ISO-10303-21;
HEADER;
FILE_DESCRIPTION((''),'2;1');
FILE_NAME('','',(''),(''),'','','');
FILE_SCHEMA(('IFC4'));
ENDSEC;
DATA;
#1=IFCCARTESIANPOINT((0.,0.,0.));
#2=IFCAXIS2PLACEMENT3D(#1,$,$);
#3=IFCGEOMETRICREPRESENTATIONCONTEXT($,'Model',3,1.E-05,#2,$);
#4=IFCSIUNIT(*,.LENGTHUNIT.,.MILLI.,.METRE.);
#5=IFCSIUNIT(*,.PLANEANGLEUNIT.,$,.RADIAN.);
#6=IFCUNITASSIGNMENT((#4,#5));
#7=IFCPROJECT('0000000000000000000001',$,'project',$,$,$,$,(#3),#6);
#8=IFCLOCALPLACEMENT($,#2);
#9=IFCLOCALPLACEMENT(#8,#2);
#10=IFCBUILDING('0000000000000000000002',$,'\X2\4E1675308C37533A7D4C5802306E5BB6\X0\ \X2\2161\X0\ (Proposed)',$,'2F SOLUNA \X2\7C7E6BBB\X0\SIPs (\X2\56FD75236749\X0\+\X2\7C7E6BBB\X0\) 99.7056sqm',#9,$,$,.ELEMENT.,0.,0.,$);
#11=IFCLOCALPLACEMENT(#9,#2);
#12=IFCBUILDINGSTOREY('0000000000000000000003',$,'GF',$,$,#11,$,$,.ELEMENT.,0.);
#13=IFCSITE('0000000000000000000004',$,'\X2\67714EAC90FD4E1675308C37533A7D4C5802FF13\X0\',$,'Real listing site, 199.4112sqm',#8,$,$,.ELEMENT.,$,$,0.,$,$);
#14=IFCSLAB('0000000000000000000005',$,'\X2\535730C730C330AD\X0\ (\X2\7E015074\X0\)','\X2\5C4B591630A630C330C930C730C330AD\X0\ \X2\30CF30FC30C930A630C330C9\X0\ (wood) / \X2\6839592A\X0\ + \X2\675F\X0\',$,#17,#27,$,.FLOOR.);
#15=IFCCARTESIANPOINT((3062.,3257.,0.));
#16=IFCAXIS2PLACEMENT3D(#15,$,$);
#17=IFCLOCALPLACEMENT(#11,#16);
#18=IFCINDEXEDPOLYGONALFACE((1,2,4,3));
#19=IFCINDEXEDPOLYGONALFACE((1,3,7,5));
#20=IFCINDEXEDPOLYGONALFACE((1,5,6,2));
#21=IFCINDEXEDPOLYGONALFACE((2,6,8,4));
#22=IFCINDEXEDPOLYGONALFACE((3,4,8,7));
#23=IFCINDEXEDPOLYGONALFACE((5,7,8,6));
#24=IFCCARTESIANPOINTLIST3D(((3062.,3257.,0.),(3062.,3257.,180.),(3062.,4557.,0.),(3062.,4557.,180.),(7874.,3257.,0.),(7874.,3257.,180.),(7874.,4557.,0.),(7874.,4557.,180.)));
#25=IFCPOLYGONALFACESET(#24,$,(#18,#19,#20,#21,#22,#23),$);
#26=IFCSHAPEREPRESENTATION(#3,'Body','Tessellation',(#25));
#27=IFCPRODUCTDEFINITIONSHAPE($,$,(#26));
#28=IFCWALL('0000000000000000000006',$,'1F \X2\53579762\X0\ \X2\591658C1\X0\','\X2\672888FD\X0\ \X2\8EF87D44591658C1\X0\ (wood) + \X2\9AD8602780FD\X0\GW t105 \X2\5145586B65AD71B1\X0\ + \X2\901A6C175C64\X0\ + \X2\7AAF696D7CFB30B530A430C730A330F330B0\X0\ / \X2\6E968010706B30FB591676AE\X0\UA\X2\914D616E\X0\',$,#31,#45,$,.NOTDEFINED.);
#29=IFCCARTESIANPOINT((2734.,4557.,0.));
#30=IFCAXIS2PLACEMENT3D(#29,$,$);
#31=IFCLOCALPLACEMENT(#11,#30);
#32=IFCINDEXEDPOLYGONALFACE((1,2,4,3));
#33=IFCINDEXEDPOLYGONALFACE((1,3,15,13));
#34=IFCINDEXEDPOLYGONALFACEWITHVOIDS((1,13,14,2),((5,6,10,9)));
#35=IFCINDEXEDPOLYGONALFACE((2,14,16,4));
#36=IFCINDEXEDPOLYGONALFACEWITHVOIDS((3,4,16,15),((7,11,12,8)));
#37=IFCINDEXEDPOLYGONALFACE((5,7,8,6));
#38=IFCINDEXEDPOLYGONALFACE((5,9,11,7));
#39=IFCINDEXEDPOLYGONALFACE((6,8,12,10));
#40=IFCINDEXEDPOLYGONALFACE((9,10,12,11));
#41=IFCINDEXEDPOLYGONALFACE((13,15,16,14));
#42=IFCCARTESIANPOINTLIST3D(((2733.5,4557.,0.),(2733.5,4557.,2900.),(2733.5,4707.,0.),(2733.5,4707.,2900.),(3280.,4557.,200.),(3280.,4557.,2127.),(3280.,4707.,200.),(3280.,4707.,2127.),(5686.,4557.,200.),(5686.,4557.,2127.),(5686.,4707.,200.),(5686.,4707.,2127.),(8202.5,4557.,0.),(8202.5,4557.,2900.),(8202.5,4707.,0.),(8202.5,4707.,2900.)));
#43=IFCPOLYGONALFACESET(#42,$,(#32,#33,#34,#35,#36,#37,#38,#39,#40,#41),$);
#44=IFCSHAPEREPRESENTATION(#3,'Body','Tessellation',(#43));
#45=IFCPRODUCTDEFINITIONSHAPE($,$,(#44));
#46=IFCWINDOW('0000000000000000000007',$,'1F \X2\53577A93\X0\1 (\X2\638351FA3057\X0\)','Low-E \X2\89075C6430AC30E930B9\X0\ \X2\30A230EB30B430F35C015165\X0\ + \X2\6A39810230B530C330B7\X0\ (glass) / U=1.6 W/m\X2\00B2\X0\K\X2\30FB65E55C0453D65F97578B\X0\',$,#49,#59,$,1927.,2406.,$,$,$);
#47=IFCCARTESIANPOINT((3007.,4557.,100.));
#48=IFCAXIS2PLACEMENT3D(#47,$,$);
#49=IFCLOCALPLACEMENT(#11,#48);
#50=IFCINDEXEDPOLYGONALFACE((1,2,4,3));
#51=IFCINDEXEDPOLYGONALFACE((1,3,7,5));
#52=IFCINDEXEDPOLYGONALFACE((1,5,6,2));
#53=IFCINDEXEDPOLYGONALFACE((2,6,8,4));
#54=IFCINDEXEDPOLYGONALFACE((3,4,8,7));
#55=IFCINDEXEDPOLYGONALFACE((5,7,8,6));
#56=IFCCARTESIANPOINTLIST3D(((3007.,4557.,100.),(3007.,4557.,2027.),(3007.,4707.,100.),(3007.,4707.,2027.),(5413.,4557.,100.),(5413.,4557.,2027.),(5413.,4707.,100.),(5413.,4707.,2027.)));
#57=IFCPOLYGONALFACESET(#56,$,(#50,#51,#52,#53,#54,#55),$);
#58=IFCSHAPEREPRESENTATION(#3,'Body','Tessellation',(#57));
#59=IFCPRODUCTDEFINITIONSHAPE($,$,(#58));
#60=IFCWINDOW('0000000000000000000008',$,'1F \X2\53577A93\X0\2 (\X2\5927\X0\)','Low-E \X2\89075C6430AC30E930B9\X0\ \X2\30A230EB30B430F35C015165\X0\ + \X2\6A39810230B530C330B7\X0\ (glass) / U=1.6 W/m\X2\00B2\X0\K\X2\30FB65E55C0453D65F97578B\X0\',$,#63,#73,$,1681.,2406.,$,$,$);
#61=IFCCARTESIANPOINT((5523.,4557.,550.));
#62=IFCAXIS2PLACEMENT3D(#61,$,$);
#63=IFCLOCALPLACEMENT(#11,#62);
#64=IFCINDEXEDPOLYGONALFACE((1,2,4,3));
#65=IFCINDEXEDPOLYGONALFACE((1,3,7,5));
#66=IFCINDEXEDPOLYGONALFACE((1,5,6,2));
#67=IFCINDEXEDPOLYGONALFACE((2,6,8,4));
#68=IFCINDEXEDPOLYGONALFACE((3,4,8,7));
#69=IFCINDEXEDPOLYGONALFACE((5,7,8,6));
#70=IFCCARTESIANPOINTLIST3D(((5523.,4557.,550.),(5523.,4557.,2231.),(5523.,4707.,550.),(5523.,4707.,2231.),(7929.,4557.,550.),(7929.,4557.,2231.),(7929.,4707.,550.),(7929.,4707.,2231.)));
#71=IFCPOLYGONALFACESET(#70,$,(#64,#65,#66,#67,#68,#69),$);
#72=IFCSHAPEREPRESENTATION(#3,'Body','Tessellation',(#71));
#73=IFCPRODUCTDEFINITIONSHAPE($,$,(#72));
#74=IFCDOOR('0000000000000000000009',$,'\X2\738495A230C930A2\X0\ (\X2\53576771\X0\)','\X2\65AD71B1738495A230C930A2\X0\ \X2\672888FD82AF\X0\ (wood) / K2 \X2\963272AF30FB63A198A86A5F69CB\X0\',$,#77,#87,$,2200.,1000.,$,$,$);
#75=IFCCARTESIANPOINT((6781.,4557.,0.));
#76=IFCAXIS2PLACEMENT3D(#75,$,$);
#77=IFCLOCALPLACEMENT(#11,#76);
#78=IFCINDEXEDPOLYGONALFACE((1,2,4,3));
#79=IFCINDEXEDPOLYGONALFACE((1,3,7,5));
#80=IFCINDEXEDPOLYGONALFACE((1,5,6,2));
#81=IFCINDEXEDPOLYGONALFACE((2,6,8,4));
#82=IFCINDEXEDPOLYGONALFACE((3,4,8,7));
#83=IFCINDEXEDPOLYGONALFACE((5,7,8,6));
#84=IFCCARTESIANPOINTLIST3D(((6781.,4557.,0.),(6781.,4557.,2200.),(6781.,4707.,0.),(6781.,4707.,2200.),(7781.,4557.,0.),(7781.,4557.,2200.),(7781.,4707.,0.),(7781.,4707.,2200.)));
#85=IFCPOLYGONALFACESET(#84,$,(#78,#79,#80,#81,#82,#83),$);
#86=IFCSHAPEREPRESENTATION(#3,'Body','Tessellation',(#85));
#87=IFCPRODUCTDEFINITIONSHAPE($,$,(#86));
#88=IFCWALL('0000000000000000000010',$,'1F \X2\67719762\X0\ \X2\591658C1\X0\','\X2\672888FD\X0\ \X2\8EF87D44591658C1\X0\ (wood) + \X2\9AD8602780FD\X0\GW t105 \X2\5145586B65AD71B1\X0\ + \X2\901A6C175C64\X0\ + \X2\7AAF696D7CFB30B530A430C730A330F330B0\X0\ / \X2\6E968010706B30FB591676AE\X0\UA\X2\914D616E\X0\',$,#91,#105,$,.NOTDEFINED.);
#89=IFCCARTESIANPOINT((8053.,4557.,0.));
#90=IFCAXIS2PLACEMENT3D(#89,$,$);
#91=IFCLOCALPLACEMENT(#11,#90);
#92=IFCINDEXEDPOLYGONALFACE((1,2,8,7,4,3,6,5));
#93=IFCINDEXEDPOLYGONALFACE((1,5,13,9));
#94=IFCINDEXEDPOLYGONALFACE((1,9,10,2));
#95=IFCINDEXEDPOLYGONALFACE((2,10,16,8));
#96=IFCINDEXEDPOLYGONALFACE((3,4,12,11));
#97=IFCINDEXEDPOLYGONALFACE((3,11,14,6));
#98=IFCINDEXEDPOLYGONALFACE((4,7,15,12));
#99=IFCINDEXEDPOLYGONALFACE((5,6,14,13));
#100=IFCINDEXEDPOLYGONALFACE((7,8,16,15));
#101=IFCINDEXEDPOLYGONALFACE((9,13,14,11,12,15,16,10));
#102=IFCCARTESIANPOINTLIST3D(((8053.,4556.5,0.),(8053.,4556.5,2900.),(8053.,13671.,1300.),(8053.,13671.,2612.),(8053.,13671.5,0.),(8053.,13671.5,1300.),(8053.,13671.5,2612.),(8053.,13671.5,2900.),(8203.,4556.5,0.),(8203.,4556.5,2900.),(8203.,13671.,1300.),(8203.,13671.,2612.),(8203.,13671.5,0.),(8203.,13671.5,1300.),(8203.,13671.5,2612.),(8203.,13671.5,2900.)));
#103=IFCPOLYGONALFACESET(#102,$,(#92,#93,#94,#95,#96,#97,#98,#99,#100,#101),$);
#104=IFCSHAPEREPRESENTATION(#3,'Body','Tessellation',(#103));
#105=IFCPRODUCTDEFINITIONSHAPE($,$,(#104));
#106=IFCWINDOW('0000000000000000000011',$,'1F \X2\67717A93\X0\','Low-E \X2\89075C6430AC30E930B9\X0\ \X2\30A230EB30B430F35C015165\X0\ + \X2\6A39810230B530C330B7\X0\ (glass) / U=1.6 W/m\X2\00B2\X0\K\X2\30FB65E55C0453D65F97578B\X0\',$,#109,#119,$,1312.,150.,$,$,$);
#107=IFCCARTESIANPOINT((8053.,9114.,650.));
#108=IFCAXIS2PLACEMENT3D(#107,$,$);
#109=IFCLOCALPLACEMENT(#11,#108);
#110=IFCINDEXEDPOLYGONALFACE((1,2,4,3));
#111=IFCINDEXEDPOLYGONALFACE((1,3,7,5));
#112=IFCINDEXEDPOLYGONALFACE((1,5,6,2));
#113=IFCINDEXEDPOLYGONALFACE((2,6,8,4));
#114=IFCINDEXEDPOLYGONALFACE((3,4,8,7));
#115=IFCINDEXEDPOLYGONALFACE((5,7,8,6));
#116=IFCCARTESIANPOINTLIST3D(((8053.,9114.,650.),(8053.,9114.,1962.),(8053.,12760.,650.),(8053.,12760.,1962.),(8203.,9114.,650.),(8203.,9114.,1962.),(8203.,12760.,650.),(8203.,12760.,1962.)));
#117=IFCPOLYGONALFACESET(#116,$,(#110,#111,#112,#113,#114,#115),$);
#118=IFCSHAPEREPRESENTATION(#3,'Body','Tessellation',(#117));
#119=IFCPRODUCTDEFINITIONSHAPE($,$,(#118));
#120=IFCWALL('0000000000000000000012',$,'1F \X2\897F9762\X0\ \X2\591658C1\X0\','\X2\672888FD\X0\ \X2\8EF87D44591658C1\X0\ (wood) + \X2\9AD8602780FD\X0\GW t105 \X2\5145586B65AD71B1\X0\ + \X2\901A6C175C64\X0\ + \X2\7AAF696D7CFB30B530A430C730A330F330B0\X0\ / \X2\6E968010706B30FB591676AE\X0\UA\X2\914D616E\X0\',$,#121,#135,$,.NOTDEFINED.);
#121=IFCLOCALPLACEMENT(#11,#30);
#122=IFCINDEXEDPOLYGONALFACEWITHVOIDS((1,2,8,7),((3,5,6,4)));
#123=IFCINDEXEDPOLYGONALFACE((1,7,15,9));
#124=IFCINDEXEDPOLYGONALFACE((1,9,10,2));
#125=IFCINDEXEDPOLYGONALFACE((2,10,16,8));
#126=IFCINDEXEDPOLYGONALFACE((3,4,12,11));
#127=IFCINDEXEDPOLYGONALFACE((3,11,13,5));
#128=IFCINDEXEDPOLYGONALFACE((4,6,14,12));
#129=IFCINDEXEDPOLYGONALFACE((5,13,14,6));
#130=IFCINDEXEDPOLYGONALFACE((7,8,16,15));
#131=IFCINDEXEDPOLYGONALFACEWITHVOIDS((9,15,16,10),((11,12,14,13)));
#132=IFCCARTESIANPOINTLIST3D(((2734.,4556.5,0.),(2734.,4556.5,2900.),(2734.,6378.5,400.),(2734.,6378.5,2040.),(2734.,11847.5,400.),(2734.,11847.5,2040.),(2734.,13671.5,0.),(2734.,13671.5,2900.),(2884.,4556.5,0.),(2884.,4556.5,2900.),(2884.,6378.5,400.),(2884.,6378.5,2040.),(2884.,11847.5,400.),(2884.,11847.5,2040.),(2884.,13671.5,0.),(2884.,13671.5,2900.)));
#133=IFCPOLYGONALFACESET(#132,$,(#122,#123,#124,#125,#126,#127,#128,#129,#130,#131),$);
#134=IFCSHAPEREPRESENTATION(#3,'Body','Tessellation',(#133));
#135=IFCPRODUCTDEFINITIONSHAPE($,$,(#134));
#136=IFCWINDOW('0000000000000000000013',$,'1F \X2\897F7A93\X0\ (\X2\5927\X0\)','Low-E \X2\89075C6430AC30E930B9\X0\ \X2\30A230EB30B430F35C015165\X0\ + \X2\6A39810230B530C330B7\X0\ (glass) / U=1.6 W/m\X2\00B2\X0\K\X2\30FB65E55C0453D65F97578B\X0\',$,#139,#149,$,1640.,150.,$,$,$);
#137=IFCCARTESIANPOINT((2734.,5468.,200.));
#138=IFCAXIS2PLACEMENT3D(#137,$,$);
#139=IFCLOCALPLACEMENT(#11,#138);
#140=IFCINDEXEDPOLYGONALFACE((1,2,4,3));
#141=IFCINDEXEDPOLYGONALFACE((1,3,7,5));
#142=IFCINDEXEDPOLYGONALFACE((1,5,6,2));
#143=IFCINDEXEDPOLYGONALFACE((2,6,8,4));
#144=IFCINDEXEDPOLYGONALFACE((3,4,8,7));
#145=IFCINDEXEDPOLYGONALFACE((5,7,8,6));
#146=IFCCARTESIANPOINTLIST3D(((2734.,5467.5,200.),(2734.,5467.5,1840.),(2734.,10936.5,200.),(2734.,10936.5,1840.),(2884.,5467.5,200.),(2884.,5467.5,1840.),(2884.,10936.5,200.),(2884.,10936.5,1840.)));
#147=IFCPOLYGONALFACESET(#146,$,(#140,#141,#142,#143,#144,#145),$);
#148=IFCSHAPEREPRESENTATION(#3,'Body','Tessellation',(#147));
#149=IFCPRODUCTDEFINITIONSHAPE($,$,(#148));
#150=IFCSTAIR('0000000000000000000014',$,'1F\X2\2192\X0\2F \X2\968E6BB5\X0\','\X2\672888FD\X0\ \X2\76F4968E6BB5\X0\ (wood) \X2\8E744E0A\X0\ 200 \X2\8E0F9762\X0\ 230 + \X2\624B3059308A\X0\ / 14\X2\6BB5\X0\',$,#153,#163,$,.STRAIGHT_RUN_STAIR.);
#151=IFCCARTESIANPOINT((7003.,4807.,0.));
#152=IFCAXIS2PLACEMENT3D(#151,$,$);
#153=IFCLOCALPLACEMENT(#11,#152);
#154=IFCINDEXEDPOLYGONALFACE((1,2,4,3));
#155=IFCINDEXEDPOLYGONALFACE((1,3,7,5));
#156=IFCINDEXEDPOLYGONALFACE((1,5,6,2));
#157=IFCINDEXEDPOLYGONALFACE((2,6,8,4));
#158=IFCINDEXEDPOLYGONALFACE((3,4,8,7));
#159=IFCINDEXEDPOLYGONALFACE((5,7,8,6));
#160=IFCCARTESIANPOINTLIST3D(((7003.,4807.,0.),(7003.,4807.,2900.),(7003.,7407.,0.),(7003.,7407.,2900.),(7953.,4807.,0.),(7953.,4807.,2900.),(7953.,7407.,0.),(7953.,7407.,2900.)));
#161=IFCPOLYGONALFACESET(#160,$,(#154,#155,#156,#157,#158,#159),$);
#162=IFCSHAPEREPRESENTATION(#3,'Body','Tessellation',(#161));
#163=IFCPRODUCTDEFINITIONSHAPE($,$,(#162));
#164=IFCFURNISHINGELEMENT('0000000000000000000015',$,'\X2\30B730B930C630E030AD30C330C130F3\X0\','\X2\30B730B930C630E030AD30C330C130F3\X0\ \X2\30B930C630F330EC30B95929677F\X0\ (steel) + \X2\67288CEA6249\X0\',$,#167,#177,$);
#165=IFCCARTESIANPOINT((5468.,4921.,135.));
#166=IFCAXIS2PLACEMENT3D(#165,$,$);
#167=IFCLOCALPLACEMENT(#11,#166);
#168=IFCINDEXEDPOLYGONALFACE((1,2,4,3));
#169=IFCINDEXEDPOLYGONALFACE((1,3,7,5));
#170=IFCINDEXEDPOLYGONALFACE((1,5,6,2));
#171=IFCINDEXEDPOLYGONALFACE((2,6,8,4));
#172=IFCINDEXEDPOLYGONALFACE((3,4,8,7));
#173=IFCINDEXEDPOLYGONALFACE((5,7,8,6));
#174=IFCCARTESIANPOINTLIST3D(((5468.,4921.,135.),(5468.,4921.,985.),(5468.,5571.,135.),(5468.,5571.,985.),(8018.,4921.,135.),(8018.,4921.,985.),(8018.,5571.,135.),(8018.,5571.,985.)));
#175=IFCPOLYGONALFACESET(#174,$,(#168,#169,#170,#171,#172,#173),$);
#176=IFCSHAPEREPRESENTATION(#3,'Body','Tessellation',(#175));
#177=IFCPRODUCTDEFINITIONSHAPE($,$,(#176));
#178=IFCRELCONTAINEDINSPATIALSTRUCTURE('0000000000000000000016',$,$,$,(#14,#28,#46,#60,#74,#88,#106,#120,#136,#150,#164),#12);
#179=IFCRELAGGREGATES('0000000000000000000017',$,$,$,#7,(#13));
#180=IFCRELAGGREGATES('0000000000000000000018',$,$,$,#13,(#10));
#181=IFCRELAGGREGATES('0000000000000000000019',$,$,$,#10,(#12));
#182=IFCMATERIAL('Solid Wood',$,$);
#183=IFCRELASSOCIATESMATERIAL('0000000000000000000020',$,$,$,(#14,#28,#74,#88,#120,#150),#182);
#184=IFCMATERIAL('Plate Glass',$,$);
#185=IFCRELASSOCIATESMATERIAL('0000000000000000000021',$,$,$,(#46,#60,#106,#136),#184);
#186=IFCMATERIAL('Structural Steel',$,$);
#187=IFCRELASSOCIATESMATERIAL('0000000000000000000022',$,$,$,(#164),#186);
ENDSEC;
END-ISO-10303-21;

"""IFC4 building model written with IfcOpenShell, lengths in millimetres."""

from ifc_helpers import new_model, si_unit, frame, frame_2d, origin, place, context, project, spatial, rectangle, extrude, material, element, fill, save


model = new_model("IFC4")

# Units and contexts
model_context = context("Model", 3, precision=1e-05, world=origin())
ifc_project = project(units=[si_unit("LENGTHUNIT", "METRE", prefix="MILLI"), si_unit("PLANEANGLEUNIT", "RADIAN")], contexts=[model_context])

# Site, building, storey
site_placement = place(None, origin())
site = spatial("IfcSite", under=ifc_project, at=site_placement, Name="東京都世田谷区経堂３", ObjectType="Real listing site, 199.4112sqm", CompositionType="ELEMENT", RefElevation=0.0)
building_placement = place(site_placement, origin())
building = spatial("IfcBuilding", under=site, at=building_placement, Name="世田谷区経堂の家 Ⅱ (Proposed)", ObjectType="2F SOLUNA 籾殻SIPs (国産杉+籾殻) 99.7056sqm", CompositionType="ELEMENT", ElevationOfRefHeight=0.0, ElevationOfTerrain=0.0)
storey_placement = place(building_placement, origin())
storey = spatial("IfcBuildingStorey", under=building, at=storey_placement, Name="GF", CompositionType="ELEMENT", Elevation=0.0)

# Slab
ifc_material_1 = material(Name="Solid Wood")
slab_1_placement = place(storey_placement, frame((3062.0, 3257.0, 0.0)))
element("IfcSlab", 1, at=slab_1_placement, inside=storey, material=ifc_material_1, Name="南デッキ (縁側)", Description="屋外ウッドデッキ ハードウッド (wood) / 根太 + 束", PredefinedType="FLOOR", context=model_context, shape_type="SweptSolid", body=[
    extrude(rectangle(XDim=4812.0, YDim=1300.0, at=frame_2d((2406.0, 650.0))), frame((3062.0, 3257.0, 0.0)), (0.0, 0.0, 1.0), 180.0),
])

# Wall, openings, windows, door
wall_1_placement = place(storey_placement, frame((2734.0, 4557.0, 0.0)))
wall_1 = element("IfcWall", 2, at=wall_1_placement, inside=storey, material=ifc_material_1, Name="1F 南面 外壁", Description="木製 軸組外壁 (wood) + 高性能GW t105 充填断熱 + 通気層 + 窯業系サイディング / 準耐火・外皮UA配慮", PredefinedType="NOTDEFINED", context=model_context, shape_type="SweptSolid", body=[
    extrude(rectangle(XDim=5469.0, YDim=150.0, at=frame_2d((2734.0, 75.0))), frame((2734.0, 4557.0, 0.0)), (0.0, 0.0, 1.0), 2900.0),
])
opening_1_placement = place(storey_placement, frame((3007.0, 4557.0, 100.0)))
opening_1 = element("IfcOpeningElement", 3, at=opening_1_placement, cuts=wall_1, PredefinedType="NOTDEFINED", context=model_context, shape_type="SweptSolid", body=[
    extrude(rectangle(XDim=2406.0, YDim=150.0, at=frame_2d((1203.0, 75.0))), frame((3007.0, 4557.0, 100.0)), (0.0, 0.0, 1.0), 1927.0),
])
opening_2_placement = place(storey_placement, frame((5523.0, 4557.0, 550.0)))
opening_2 = element("IfcOpeningElement", 4, at=opening_2_placement, cuts=wall_1, PredefinedType="NOTDEFINED", context=model_context, shape_type="SweptSolid", body=[
    extrude(rectangle(XDim=2406.0, YDim=150.0, at=frame_2d((1203.0, 75.0))), frame((5523.0, 4557.0, 550.0)), (0.0, 0.0, 1.0), 1681.0),
])
opening_3_placement = place(storey_placement, frame((6781.0, 4557.0, 0.0)))
opening_3 = element("IfcOpeningElement", 5, at=opening_3_placement, cuts=wall_1, PredefinedType="NOTDEFINED", context=model_context, shape_type="SweptSolid", body=[
    extrude(rectangle(XDim=1000.0, YDim=150.0, at=frame_2d((500.0, 75.0))), frame((6781.0, 4557.0, 0.0)), (0.0, 0.0, 1.0), 2200.0),
])
ifc_material_2 = material(Name="Plate Glass")
window_1_placement = place(storey_placement, frame((3007.0, 4557.0, 100.0)))
window_1 = element("IfcWindow", 6, at=window_1_placement, inside=storey, material=ifc_material_2, Name="1F 南窓1 (掃出し)", Description="Low-E 複層ガラス アルゴン封入 + 樹脂サッシ (glass) / U=1.6 W/m²K・日射取得型", OverallHeight=1927.0, OverallWidth=2406.0, context=model_context, shape_type="SweptSolid", body=[
    extrude(rectangle(XDim=2406.0, YDim=150.0, at=frame_2d((1203.0, 75.0))), frame((3007.0, 4557.0, 100.0)), (0.0, 0.0, 1.0), 1927.0),
])
fill(opening_1, window_1)
window_2_placement = place(storey_placement, frame((5523.0, 4557.0, 550.0)))
window_2 = element("IfcWindow", 7, at=window_2_placement, inside=storey, material=ifc_material_2, Name="1F 南窓2 (大)", Description="Low-E 複層ガラス アルゴン封入 + 樹脂サッシ (glass) / U=1.6 W/m²K・日射取得型", OverallHeight=1681.0, OverallWidth=2406.0, context=model_context, shape_type="SweptSolid", body=[
    extrude(rectangle(XDim=2406.0, YDim=150.0, at=frame_2d((1203.0, 75.0))), frame((5523.0, 4557.0, 550.0)), (0.0, 0.0, 1.0), 1681.0),
])
fill(opening_2, window_2)
door_placement = place(storey_placement, frame((6781.0, 4557.0, 0.0)))
door = element("IfcDoor", 8, at=door_placement, inside=storey, material=ifc_material_1, Name="玄関ドア (南東)", Description="断熱玄関ドア 木製芯 (wood) / K2 防犯・採風機構", OverallHeight=2200.0, OverallWidth=1000.0, context=model_context, shape_type="SweptSolid", body=[
    extrude(rectangle(XDim=1000.0, YDim=150.0, at=frame_2d((500.0, 75.0))), frame((6781.0, 4557.0, 0.0)), (0.0, 0.0, 1.0), 2200.0),
])
fill(opening_3, door)

# Walls, openings, windows
wall_2_placement = place(storey_placement, frame((8053.0, 4557.0, 0.0)))
wall_2 = element("IfcWall", 9, at=wall_2_placement, inside=storey, material=ifc_material_1, Name="1F 東面 外壁", Description="木製 軸組外壁 (wood) + 高性能GW t105 充填断熱 + 通気層 + 窯業系サイディング / 準耐火・外皮UA配慮", PredefinedType="NOTDEFINED", context=model_context, shape_type="SweptSolid", body=[
    extrude(rectangle(XDim=150.0, YDim=9115.0, at=frame_2d((75.0, 4557.0))), frame((8053.0, 4557.0, 0.0)), (0.0, 0.0, 1.0), 2900.0),
])
opening_4_placement = place(storey_placement, frame((8053.0, 9114.0, 650.0)))
opening_4 = element("IfcOpeningElement", 10, at=opening_4_placement, cuts=wall_2, PredefinedType="NOTDEFINED", context=model_context, shape_type="SweptSolid", body=[
    extrude(rectangle(XDim=150.0, YDim=3646.0, at=frame_2d((75.0, 1823.0))), frame((8053.0, 9114.0, 650.0)), (0.0, 0.0, 1.0), 1312.0),
])
window_3_placement = place(storey_placement, frame((8053.0, 9114.0, 650.0)))
window_3 = element("IfcWindow", 11, at=window_3_placement, inside=storey, material=ifc_material_2, Name="1F 東窓", Description="Low-E 複層ガラス アルゴン封入 + 樹脂サッシ (glass) / U=1.6 W/m²K・日射取得型", OverallHeight=1312.0, OverallWidth=150.0, context=model_context, shape_type="SweptSolid", body=[
    extrude(rectangle(XDim=150.0, YDim=3646.0, at=frame_2d((75.0, 1823.0))), frame((8053.0, 9114.0, 650.0)), (0.0, 0.0, 1.0), 1312.0),
])
fill(opening_4, window_3)
wall_3_placement = place(storey_placement, frame((2734.0, 4557.0, 0.0)))
wall_3 = element("IfcWall", 12, at=wall_3_placement, inside=storey, material=ifc_material_1, Name="1F 西面 外壁", Description="木製 軸組外壁 (wood) + 高性能GW t105 充填断熱 + 通気層 + 窯業系サイディング / 準耐火・外皮UA配慮", PredefinedType="NOTDEFINED", context=model_context, shape_type="SweptSolid", body=[
    extrude(rectangle(XDim=150.0, YDim=9115.0, at=frame_2d((75.0, 4557.0))), frame((2734.0, 4557.0, 0.0)), (0.0, 0.0, 1.0), 2900.0),
])
opening_5_placement = place(storey_placement, frame((2734.0, 5468.0, 200.0)))
opening_5 = element("IfcOpeningElement", 13, at=opening_5_placement, cuts=wall_3, PredefinedType="NOTDEFINED", context=model_context, shape_type="SweptSolid", body=[
    extrude(rectangle(XDim=150.0, YDim=5469.0, at=frame_2d((75.0, 2734.0))), frame((2734.0, 5468.0, 200.0)), (0.0, 0.0, 1.0), 1640.0),
])
window_4_placement = place(storey_placement, frame((2734.0, 5468.0, 200.0)))
window_4 = element("IfcWindow", 14, at=window_4_placement, inside=storey, material=ifc_material_2, Name="1F 西窓 (大)", Description="Low-E 複層ガラス アルゴン封入 + 樹脂サッシ (glass) / U=1.6 W/m²K・日射取得型", OverallHeight=1640.0, OverallWidth=150.0, context=model_context, shape_type="SweptSolid", body=[
    extrude(rectangle(XDim=150.0, YDim=5469.0, at=frame_2d((75.0, 2734.0))), frame((2734.0, 5468.0, 200.0)), (0.0, 0.0, 1.0), 1640.0),
])
fill(opening_5, window_4)

# Stair
stair_placement = place(storey_placement, frame((7003.0, 4807.0, 0.0)))
element("IfcStair", 15, at=stair_placement, inside=storey, material=ifc_material_1, Name="1F→2F 階段", Description="木製 直階段 (wood) 蹴上 200 踏面 230 + 手すり / 14段", PredefinedType="STRAIGHT_RUN_STAIR", context=model_context, shape_type="SweptSolid", body=[
    extrude(rectangle(XDim=950.0, YDim=2600.0, at=frame_2d((475.0, 1300.0))), frame((7003.0, 4807.0, 0.0)), (0.0, 0.0, 1.0), 2900.0),
])

# Furnishing element
ifc_material_3 = material(Name="Structural Steel")
furnishing_placement = place(storey_placement, frame((5468.0, 4921.0, 135.0)))
element("IfcFurnishingElement", 16, at=furnishing_placement, inside=storey, material=ifc_material_3, Name="システムキッチン", Description="システムキッチン ステンレス天板 (steel) + 木質扉", context=model_context, shape_type="SweptSolid", body=[
    extrude(rectangle(XDim=2550.0, YDim=650.0, at=frame_2d((1275.0, 325.0))), frame((5468.0, 4921.0, 135.0)), (0.0, 0.0, 1.0), 850.0),
])

save(model, "model.ifc")
